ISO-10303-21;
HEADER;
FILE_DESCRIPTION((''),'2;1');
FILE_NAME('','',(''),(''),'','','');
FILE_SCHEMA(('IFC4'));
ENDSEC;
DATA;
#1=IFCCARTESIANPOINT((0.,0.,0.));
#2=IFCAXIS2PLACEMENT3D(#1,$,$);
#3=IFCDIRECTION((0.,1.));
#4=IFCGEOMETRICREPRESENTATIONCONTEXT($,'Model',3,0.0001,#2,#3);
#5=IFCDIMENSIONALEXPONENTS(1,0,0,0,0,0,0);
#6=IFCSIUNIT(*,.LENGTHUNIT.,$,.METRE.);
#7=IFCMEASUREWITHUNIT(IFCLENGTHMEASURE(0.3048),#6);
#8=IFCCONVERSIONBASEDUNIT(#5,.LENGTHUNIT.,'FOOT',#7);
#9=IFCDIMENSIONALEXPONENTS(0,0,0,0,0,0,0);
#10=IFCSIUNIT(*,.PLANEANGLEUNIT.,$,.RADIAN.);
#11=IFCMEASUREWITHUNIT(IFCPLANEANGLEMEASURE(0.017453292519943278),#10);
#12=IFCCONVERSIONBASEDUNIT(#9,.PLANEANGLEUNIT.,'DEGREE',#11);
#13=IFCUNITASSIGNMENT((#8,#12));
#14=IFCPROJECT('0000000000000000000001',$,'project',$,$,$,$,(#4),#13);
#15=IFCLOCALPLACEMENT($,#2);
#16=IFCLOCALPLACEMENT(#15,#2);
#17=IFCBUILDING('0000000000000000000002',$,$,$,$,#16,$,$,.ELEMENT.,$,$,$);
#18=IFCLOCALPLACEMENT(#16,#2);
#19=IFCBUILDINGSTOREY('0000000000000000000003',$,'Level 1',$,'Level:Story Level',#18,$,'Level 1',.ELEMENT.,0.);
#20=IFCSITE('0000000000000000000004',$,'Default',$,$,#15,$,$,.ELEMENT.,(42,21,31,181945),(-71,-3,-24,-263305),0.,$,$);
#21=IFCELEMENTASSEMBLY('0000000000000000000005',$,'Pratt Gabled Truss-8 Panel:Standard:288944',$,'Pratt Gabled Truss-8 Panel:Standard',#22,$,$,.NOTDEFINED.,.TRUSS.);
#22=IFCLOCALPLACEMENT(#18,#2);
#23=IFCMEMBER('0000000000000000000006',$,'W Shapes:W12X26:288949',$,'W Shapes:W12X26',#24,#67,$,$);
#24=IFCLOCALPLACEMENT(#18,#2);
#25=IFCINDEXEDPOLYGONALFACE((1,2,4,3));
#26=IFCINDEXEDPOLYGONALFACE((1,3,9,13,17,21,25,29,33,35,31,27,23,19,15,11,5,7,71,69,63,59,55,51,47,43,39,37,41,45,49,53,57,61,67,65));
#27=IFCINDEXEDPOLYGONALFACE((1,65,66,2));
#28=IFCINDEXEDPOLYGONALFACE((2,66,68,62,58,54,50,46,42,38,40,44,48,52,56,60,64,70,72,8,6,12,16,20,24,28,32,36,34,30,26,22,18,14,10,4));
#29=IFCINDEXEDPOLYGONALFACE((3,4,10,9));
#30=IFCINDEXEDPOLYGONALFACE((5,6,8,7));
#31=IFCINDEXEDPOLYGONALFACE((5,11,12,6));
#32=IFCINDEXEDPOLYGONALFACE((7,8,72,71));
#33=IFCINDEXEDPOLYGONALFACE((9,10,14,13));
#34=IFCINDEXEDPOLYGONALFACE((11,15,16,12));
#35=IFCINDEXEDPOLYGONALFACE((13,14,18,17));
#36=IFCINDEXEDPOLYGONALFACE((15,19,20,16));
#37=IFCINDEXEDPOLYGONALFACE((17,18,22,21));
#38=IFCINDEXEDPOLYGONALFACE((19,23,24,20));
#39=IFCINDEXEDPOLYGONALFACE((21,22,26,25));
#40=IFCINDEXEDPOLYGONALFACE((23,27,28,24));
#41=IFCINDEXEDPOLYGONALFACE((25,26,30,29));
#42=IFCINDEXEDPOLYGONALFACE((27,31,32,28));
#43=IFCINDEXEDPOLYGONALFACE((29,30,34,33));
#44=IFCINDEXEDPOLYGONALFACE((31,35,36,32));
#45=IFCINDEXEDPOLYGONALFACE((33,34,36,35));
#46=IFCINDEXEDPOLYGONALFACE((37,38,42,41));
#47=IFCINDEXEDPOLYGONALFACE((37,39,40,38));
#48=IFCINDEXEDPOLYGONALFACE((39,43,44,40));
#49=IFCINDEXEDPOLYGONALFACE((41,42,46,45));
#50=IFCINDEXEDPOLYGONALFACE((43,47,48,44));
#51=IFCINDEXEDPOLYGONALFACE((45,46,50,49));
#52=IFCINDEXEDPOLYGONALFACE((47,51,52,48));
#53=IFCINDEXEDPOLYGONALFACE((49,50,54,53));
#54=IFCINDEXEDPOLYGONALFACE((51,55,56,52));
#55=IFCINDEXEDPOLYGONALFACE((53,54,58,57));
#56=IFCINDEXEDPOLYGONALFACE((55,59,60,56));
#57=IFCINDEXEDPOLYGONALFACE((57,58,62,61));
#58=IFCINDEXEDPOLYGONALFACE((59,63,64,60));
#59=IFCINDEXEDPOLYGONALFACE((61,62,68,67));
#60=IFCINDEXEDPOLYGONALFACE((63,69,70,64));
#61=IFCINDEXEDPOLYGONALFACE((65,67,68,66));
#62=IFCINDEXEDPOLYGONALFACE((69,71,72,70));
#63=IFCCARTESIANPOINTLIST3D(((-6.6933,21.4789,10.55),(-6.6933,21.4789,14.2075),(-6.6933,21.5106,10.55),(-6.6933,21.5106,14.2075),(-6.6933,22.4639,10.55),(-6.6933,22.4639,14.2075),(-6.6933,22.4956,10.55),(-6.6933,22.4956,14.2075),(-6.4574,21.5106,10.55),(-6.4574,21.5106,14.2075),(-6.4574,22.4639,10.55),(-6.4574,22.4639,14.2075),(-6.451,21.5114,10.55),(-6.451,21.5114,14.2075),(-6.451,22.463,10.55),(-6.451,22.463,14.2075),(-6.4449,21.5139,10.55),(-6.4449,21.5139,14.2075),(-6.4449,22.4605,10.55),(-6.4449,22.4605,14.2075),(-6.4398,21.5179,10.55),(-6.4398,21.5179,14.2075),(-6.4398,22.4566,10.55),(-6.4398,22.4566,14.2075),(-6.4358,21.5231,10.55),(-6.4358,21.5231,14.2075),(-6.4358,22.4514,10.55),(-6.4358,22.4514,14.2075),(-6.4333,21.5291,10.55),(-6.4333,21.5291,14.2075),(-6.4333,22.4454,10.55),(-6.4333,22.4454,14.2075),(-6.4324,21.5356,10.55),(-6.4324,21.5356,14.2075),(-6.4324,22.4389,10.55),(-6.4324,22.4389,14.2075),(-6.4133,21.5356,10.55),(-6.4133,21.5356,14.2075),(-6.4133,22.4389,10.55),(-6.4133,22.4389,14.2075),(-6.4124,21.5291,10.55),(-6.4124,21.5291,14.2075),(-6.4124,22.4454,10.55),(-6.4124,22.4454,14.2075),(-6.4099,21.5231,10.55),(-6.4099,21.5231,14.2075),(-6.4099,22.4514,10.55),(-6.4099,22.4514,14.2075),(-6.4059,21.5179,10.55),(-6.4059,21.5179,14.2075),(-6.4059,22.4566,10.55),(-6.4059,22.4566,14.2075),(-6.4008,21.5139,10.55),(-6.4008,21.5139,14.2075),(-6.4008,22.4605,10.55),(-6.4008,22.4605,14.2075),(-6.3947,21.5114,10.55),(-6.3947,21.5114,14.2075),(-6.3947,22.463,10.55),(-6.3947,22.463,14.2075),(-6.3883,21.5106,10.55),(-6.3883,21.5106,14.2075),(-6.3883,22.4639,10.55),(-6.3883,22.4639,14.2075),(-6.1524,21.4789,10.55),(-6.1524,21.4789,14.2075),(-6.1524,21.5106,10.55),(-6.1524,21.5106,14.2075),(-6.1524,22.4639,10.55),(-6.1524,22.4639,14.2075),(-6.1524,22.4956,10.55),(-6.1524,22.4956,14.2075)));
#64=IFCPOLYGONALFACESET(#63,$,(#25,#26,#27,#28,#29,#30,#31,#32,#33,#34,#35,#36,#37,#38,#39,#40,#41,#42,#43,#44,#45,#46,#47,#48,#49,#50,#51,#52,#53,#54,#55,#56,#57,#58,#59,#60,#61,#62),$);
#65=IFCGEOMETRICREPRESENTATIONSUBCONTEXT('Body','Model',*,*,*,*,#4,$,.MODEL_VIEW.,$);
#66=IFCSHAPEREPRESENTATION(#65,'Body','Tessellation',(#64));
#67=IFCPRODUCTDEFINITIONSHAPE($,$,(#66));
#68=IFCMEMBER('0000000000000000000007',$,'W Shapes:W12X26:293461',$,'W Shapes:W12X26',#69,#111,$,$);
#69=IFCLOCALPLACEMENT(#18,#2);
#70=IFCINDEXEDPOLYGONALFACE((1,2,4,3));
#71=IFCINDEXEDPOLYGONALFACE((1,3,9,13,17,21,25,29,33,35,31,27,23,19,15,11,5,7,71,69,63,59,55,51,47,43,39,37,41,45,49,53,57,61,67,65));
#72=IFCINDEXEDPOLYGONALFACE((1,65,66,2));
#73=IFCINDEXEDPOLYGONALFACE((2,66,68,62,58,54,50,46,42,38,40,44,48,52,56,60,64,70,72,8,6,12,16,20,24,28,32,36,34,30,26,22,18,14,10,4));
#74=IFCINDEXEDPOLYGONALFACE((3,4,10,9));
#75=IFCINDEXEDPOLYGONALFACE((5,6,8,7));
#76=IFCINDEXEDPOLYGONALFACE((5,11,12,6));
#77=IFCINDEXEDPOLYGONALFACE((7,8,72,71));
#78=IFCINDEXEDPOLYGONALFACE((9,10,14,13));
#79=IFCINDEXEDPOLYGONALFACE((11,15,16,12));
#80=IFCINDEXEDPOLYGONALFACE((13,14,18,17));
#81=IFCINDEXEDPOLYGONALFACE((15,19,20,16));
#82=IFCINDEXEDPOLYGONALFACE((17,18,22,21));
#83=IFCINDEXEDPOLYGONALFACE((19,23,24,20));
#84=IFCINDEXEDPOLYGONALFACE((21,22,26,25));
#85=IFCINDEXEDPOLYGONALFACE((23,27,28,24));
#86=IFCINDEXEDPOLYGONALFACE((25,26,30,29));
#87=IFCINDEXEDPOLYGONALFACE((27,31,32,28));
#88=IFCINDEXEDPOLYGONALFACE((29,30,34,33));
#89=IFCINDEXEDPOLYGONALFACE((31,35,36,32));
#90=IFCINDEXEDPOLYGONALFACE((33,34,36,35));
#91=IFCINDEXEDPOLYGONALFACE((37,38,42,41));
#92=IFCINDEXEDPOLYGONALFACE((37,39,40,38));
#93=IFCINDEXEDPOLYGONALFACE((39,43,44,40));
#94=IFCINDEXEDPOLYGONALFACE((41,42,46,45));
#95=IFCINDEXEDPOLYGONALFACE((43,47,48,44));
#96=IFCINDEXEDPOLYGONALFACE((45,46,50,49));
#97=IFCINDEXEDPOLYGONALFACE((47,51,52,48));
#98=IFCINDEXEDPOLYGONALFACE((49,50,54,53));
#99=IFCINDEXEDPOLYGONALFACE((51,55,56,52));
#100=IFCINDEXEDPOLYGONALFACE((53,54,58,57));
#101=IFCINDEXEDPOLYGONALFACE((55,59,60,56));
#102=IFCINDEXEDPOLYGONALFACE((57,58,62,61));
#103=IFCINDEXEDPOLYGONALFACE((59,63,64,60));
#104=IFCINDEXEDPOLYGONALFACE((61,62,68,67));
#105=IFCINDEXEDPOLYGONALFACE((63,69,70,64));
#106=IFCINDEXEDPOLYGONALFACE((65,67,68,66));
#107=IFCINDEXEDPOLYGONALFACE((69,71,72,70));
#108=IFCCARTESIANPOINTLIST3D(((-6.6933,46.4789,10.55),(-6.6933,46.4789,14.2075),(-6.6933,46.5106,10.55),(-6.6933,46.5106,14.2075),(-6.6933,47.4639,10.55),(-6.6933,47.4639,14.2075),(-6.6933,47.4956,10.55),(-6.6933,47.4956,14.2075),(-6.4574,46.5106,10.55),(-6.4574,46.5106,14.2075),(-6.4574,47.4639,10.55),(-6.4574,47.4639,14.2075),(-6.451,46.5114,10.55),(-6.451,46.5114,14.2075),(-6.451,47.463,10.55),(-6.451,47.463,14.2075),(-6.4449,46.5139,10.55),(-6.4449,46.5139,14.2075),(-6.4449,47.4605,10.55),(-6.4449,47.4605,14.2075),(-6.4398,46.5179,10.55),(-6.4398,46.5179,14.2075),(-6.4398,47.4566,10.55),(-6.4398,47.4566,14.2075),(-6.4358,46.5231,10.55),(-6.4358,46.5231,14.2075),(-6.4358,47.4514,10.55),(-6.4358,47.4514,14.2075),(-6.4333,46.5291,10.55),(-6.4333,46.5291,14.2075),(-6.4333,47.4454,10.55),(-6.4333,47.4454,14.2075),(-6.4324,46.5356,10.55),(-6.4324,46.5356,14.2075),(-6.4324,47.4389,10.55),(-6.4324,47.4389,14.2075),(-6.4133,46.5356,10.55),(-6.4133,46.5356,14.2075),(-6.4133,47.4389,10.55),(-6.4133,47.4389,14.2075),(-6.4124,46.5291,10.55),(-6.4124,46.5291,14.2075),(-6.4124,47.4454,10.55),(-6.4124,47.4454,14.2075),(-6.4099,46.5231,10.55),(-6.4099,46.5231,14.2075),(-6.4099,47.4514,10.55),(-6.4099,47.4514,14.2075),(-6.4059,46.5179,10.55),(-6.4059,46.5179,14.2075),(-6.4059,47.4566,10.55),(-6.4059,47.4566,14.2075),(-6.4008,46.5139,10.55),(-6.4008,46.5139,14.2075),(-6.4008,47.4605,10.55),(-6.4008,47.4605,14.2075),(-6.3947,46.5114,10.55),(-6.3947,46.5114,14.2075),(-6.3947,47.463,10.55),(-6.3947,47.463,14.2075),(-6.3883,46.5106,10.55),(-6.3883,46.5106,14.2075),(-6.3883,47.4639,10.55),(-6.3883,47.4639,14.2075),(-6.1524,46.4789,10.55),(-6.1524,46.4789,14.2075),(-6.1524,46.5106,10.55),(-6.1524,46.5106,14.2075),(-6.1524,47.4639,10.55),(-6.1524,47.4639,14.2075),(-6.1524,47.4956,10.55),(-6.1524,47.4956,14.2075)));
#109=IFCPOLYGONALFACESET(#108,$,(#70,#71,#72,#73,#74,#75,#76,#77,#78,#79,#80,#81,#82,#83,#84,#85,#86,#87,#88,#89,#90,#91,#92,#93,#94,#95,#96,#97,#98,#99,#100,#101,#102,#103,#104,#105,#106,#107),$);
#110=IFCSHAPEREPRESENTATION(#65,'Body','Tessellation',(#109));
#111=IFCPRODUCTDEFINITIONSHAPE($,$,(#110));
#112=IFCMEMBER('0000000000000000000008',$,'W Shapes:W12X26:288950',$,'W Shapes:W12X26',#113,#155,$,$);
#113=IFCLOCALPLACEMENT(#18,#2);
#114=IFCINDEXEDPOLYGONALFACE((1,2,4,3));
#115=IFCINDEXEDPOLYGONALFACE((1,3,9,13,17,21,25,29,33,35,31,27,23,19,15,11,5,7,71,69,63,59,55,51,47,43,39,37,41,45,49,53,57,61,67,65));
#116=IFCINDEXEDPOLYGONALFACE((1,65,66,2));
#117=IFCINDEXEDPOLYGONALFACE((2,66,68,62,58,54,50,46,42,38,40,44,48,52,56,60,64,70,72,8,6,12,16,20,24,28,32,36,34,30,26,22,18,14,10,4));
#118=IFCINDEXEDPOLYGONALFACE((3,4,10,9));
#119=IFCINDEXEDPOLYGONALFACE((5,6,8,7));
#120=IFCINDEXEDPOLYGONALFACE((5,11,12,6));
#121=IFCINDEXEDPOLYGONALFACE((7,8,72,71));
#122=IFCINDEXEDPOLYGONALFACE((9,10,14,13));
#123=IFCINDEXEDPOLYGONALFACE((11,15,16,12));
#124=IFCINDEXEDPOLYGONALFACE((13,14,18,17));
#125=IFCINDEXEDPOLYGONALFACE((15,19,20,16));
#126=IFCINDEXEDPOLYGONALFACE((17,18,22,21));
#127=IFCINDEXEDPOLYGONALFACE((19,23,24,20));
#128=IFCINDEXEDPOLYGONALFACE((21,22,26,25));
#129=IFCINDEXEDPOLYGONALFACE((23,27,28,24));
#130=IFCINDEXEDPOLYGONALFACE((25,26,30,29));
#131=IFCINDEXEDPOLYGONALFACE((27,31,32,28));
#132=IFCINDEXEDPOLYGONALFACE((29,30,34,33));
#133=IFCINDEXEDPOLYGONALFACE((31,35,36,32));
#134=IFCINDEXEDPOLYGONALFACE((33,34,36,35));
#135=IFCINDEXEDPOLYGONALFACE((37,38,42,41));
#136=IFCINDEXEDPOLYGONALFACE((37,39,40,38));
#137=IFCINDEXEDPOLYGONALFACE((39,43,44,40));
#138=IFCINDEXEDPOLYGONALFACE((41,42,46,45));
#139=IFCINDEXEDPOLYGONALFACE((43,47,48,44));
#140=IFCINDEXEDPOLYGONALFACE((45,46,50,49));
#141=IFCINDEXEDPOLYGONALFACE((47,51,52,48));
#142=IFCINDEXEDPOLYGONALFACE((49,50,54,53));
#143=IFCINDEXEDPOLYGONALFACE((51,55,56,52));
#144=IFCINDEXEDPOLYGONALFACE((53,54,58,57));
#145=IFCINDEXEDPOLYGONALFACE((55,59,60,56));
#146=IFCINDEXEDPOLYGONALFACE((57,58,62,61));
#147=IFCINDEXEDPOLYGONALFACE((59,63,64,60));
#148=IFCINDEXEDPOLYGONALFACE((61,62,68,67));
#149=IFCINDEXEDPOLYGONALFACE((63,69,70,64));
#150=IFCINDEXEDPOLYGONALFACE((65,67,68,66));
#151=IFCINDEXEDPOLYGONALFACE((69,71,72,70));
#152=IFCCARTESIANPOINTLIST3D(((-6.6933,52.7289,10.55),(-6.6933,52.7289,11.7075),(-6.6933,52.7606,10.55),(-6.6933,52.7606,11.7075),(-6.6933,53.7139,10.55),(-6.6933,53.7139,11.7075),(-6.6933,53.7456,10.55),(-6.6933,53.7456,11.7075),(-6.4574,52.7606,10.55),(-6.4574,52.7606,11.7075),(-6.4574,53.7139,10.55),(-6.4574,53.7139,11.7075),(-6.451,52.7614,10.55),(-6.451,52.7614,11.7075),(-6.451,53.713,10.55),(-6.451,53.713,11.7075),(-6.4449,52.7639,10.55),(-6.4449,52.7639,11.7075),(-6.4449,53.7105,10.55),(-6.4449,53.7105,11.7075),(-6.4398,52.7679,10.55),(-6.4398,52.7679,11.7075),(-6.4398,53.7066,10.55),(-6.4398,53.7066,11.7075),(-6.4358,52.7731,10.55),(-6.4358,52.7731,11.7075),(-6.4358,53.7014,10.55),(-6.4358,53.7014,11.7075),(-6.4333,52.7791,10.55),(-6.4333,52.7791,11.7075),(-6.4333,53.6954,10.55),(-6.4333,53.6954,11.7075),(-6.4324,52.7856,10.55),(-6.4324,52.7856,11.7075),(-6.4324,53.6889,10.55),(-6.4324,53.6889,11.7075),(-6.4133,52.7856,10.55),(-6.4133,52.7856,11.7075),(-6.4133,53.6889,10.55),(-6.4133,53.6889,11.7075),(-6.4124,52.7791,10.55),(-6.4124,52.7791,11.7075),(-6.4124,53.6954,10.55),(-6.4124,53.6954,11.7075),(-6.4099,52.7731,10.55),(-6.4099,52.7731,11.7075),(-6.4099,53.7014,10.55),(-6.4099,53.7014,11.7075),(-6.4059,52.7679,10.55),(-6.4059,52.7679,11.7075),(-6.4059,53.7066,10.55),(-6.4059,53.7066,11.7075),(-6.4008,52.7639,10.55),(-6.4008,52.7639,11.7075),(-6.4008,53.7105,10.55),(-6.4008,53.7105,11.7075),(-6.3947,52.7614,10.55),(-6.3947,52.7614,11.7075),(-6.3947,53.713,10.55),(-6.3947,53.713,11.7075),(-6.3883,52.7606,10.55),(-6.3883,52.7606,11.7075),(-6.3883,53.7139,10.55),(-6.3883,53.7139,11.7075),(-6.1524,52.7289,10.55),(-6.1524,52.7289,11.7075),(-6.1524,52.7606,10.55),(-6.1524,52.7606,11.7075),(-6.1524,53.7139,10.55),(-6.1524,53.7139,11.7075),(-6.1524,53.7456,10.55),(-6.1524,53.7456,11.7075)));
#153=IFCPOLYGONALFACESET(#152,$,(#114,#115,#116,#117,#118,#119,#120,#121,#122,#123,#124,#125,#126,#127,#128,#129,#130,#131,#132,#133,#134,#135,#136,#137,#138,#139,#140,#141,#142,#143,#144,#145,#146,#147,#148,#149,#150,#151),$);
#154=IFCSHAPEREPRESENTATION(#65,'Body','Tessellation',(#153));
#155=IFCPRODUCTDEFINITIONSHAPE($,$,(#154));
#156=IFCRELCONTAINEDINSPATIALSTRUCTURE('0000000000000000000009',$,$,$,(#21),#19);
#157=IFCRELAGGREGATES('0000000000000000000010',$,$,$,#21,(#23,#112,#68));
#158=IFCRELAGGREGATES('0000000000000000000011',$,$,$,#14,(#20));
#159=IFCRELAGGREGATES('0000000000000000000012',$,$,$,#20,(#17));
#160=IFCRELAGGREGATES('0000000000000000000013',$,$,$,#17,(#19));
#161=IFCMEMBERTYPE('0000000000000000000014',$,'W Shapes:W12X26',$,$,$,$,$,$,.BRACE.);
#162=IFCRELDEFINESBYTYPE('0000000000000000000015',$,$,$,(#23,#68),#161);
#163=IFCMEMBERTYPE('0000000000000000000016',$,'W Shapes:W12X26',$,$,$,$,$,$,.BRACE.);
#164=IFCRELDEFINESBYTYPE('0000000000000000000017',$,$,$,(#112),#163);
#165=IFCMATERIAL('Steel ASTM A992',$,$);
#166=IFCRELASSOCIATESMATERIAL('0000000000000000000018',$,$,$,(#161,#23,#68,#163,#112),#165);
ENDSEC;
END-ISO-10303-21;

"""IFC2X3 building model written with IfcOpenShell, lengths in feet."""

from ifc_helpers import new_model, entity, si_unit, converted_unit, direction, frame, frame_2d, origin, place, context, subcontext, project, spatial, polyline, circle_curve, parameter, trimmed, segment, composite_curve, outline, extrude, source, transform, mapped, material, type_object, type_shapes, element, aggregate, save


model = new_model("IFC2X3")

# Units and contexts
model_context = context("Model", 3, precision=0.0001, world=origin(), true_north=direction((0.0, 1.0)))
body_context = subcontext(model_context, "Body", "Model", "MODEL_VIEW")
ifc_project = project(units=[converted_unit("LENGTHUNIT", "FOOT", entity("IfcLengthMeasure", 0.3048), si_unit("LENGTHUNIT", "METRE"), dimensions=[1, 0, 0, 0, 0, 0, 0]), converted_unit("PLANEANGLEUNIT", "DEGREE", entity("IfcPlaneAngleMeasure", 0.017453292519943278), si_unit("PLANEANGLEUNIT", "RADIAN"), dimensions=[0, 0, 0, 0, 0, 0, 0])], contexts=[model_context])

# Site, building, storey
site_placement = place(None, origin())
site = spatial("IfcSite", under=ifc_project, at=site_placement, Name="Default", CompositionType="ELEMENT", RefLatitude=(42, 21, 31, 181945), RefLongitude=(-71, -3, -24, -263305), RefElevation=0.0)
building_placement = place(site_placement, origin())
building = spatial("IfcBuilding", under=site, at=building_placement, CompositionType="ELEMENT")
storey_placement = place(building_placement, origin())
storey = spatial("IfcBuildingStorey", under=building, at=storey_placement, Name="Level 1", ObjectType="Level:Story Level", LongName="Level 1", CompositionType="ELEMENT", Elevation=0.0)

# Element assembly, members
assembly_placement = place(storey_placement, origin())
assembly = element("IfcElementAssembly", 1, at=assembly_placement, inside=storey, Name="Pratt Gabled Truss-8 Panel:Standard:288944", ObjectType="Pratt Gabled Truss-8 Panel:Standard", AssemblyPlace="NOTDEFINED", PredefinedType="TRUSS")
ifc_material = material(Name="Steel ASTM A992")
member_type_1 = type_object("IfcMemberType", Name="W Shapes:W12X26", PredefinedType="BRACE", material=ifc_material)
shared_shape_1 = source(origin(), body_context, "Body", "SweptSolid", [
    extrude(outline(composite_curve([segment(polyline([(-0.2704, -0.4767), (-0.2704, -0.5083)]), True, "CONTINUOUS"), segment(polyline([(-0.2704, -0.5083), (0.2704, -0.5083)]), True, "CONTINUOUS"), segment(polyline([(0.2704, -0.5083), (0.2704, -0.4767)]), True, "CONTINUOUS"), segment(polyline([(0.2704, -0.4767), (0.0346, -0.4767)]), True, "CONTINUOUS"), segment(trimmed(circle_curve(frame_2d((0.0346, -0.4517), x_axis=(0.0, -1.0)), 0.025), [parameter(270.0)], [parameter(360.0)], True, "PARAMETER"), False, "CONTINUOUS"), segment(polyline([(0.0096, -0.4517), (0.0096, 0.4517)]), True, "CONTINUOUS"), segment(trimmed(circle_curve(frame_2d((0.0346, 0.4517), x_axis=(-1.0, 0.0)), 0.025), [parameter(270.0)], [parameter(360.0)], True, "PARAMETER"), False, "CONTINUOUS"), segment(polyline([(0.0346, 0.4767), (0.2704, 0.4767)]), True, "CONTINUOUS"), segment(polyline([(0.2704, 0.4767), (0.2704, 0.5083)]), True, "CONTINUOUS"), segment(polyline([(0.2704, 0.5083), (-0.2704, 0.5083)]), True, "CONTINUOUS"), segment(polyline([(-0.2704, 0.5083), (-0.2704, 0.4767)]), True, "CONTINUOUS"), segment(polyline([(-0.2704, 0.4767), (-0.0346, 0.4767)]), True, "CONTINUOUS"), segment(trimmed(circle_curve(frame_2d((-0.0346, 0.4517), x_axis=(0.0, 1.0)), 0.025), [parameter(270.0)], [parameter(0.0)], True, "PARAMETER"), False, "CONTINUOUS"), segment(polyline([(-0.0096, 0.4517), (-0.0096, -0.4517)]), True, "CONTINUOUS"), segment(trimmed(circle_curve(frame_2d((-0.0346, -0.4517), x_axis=(1.0, 0.0)), 0.025), [parameter(270.0)], [parameter(0.0)], True, "PARAMETER"), False, "CONTINUOUS"), segment(polyline([(-0.0346, -0.4767), (-0.2704, -0.4767)]), True, "CONTINUOUS")], self_intersect=False)), frame((-1.95, 0.0, 0.0), z_axis=(-1.0, 0.0, 0.0), x_axis=(0.0, -1.0, 0.0)), (0.0, 0.0, -1.0), 3.6575),
])
type_shapes(member_type_1, [shared_shape_1])
member_1_placement = place(assembly_placement, frame((-6.4228, 21.9872, 12.5), z_axis=(0.0, 1.0, 0.0), x_axis=(0.0, 0.0, 1.0)))
member_1 = element("IfcMember", 2, at=member_1_placement, type_object=member_type_1, material=ifc_material, Name="W Shapes:W12X26:288949", ObjectType="W Shapes:W12X26", context=body_context, shape_type="MappedRepresentation", body=[
    mapped(shared_shape_1, transform((0.0, 0.0, 0.0), scale=1.0)),
])
member_2_placement = place(assembly_placement, frame((-6.4228, 46.9872, 12.5), z_axis=(0.0, 1.0, 0.0), x_axis=(0.0, 0.0, 1.0)))
member_2 = element("IfcMember", 3, at=member_2_placement, type_object=member_type_1, material=ifc_material, Name="W Shapes:W12X26:293461", ObjectType="W Shapes:W12X26", context=body_context, shape_type="MappedRepresentation", body=[
    mapped(shared_shape_1, transform((0.0, 0.0, 0.0), scale=1.0)),
])
member_type_2 = type_object("IfcMemberType", Name="W Shapes:W12X26", PredefinedType="BRACE", material=ifc_material)
shared_shape_2 = source(origin(), body_context, "Body", "SweptSolid", [
    extrude(outline(composite_curve([segment(polyline([(-0.2704, -0.4767), (-0.2704, -0.5083)]), True, "CONTINUOUS"), segment(polyline([(-0.2704, -0.5083), (0.2704, -0.5083)]), True, "CONTINUOUS"), segment(polyline([(0.2704, -0.5083), (0.2704, -0.4767)]), True, "CONTINUOUS"), segment(polyline([(0.2704, -0.4767), (0.0346, -0.4767)]), True, "CONTINUOUS"), segment(trimmed(circle_curve(frame_2d((0.0346, -0.4517), x_axis=(0.0, -1.0)), 0.025), [parameter(270.0)], [parameter(360.0)], True, "PARAMETER"), False, "CONTINUOUS"), segment(polyline([(0.0096, -0.4517), (0.0096, 0.4517)]), True, "CONTINUOUS"), segment(trimmed(circle_curve(frame_2d((0.0346, 0.4517), x_axis=(-1.0, 0.0)), 0.025), [parameter(270.0)], [parameter(360.0)], True, "PARAMETER"), False, "CONTINUOUS"), segment(polyline([(0.0346, 0.4767), (0.2704, 0.4767)]), True, "CONTINUOUS"), segment(polyline([(0.2704, 0.4767), (0.2704, 0.5083)]), True, "CONTINUOUS"), segment(polyline([(0.2704, 0.5083), (-0.2704, 0.5083)]), True, "CONTINUOUS"), segment(polyline([(-0.2704, 0.5083), (-0.2704, 0.4767)]), True, "CONTINUOUS"), segment(polyline([(-0.2704, 0.4767), (-0.0346, 0.4767)]), True, "CONTINUOUS"), segment(trimmed(circle_curve(frame_2d((-0.0346, 0.4517), x_axis=(0.0, 1.0)), 0.025), [parameter(270.0)], [parameter(0.0)], True, "PARAMETER"), False, "CONTINUOUS"), segment(polyline([(-0.0096, 0.4517), (-0.0096, -0.4517)]), True, "CONTINUOUS"), segment(trimmed(circle_curve(frame_2d((-0.0346, -0.4517), x_axis=(1.0, 0.0)), 0.025), [parameter(270.0)], [parameter(0.0)], True, "PARAMETER"), False, "CONTINUOUS"), segment(polyline([(-0.0346, -0.4767), (-0.2704, -0.4767)]), True, "CONTINUOUS")], self_intersect=False)), frame((-0.7, 0.0, 0.0), z_axis=(-1.0, 0.0, 0.0), x_axis=(0.0, -1.0, 0.0)), (0.0, 0.0, -1.0), 1.1575),
])
type_shapes(member_type_2, [shared_shape_2])
member_3_placement = place(assembly_placement, frame((-6.4228, 53.2372, 11.25), z_axis=(0.0, 1.0, 0.0), x_axis=(0.0, 0.0, 1.0)))
member_3 = element("IfcMember", 4, at=member_3_placement, type_object=member_type_2, material=ifc_material, Name="W Shapes:W12X26:288950", ObjectType="W Shapes:W12X26", context=body_context, shape_type="MappedRepresentation", body=[
    mapped(shared_shape_2, transform((0.0, 0.0, 0.0), scale=1.0)),
])
aggregate(assembly, [member_1, member_3, member_2])

save(model, "model.ifc")
